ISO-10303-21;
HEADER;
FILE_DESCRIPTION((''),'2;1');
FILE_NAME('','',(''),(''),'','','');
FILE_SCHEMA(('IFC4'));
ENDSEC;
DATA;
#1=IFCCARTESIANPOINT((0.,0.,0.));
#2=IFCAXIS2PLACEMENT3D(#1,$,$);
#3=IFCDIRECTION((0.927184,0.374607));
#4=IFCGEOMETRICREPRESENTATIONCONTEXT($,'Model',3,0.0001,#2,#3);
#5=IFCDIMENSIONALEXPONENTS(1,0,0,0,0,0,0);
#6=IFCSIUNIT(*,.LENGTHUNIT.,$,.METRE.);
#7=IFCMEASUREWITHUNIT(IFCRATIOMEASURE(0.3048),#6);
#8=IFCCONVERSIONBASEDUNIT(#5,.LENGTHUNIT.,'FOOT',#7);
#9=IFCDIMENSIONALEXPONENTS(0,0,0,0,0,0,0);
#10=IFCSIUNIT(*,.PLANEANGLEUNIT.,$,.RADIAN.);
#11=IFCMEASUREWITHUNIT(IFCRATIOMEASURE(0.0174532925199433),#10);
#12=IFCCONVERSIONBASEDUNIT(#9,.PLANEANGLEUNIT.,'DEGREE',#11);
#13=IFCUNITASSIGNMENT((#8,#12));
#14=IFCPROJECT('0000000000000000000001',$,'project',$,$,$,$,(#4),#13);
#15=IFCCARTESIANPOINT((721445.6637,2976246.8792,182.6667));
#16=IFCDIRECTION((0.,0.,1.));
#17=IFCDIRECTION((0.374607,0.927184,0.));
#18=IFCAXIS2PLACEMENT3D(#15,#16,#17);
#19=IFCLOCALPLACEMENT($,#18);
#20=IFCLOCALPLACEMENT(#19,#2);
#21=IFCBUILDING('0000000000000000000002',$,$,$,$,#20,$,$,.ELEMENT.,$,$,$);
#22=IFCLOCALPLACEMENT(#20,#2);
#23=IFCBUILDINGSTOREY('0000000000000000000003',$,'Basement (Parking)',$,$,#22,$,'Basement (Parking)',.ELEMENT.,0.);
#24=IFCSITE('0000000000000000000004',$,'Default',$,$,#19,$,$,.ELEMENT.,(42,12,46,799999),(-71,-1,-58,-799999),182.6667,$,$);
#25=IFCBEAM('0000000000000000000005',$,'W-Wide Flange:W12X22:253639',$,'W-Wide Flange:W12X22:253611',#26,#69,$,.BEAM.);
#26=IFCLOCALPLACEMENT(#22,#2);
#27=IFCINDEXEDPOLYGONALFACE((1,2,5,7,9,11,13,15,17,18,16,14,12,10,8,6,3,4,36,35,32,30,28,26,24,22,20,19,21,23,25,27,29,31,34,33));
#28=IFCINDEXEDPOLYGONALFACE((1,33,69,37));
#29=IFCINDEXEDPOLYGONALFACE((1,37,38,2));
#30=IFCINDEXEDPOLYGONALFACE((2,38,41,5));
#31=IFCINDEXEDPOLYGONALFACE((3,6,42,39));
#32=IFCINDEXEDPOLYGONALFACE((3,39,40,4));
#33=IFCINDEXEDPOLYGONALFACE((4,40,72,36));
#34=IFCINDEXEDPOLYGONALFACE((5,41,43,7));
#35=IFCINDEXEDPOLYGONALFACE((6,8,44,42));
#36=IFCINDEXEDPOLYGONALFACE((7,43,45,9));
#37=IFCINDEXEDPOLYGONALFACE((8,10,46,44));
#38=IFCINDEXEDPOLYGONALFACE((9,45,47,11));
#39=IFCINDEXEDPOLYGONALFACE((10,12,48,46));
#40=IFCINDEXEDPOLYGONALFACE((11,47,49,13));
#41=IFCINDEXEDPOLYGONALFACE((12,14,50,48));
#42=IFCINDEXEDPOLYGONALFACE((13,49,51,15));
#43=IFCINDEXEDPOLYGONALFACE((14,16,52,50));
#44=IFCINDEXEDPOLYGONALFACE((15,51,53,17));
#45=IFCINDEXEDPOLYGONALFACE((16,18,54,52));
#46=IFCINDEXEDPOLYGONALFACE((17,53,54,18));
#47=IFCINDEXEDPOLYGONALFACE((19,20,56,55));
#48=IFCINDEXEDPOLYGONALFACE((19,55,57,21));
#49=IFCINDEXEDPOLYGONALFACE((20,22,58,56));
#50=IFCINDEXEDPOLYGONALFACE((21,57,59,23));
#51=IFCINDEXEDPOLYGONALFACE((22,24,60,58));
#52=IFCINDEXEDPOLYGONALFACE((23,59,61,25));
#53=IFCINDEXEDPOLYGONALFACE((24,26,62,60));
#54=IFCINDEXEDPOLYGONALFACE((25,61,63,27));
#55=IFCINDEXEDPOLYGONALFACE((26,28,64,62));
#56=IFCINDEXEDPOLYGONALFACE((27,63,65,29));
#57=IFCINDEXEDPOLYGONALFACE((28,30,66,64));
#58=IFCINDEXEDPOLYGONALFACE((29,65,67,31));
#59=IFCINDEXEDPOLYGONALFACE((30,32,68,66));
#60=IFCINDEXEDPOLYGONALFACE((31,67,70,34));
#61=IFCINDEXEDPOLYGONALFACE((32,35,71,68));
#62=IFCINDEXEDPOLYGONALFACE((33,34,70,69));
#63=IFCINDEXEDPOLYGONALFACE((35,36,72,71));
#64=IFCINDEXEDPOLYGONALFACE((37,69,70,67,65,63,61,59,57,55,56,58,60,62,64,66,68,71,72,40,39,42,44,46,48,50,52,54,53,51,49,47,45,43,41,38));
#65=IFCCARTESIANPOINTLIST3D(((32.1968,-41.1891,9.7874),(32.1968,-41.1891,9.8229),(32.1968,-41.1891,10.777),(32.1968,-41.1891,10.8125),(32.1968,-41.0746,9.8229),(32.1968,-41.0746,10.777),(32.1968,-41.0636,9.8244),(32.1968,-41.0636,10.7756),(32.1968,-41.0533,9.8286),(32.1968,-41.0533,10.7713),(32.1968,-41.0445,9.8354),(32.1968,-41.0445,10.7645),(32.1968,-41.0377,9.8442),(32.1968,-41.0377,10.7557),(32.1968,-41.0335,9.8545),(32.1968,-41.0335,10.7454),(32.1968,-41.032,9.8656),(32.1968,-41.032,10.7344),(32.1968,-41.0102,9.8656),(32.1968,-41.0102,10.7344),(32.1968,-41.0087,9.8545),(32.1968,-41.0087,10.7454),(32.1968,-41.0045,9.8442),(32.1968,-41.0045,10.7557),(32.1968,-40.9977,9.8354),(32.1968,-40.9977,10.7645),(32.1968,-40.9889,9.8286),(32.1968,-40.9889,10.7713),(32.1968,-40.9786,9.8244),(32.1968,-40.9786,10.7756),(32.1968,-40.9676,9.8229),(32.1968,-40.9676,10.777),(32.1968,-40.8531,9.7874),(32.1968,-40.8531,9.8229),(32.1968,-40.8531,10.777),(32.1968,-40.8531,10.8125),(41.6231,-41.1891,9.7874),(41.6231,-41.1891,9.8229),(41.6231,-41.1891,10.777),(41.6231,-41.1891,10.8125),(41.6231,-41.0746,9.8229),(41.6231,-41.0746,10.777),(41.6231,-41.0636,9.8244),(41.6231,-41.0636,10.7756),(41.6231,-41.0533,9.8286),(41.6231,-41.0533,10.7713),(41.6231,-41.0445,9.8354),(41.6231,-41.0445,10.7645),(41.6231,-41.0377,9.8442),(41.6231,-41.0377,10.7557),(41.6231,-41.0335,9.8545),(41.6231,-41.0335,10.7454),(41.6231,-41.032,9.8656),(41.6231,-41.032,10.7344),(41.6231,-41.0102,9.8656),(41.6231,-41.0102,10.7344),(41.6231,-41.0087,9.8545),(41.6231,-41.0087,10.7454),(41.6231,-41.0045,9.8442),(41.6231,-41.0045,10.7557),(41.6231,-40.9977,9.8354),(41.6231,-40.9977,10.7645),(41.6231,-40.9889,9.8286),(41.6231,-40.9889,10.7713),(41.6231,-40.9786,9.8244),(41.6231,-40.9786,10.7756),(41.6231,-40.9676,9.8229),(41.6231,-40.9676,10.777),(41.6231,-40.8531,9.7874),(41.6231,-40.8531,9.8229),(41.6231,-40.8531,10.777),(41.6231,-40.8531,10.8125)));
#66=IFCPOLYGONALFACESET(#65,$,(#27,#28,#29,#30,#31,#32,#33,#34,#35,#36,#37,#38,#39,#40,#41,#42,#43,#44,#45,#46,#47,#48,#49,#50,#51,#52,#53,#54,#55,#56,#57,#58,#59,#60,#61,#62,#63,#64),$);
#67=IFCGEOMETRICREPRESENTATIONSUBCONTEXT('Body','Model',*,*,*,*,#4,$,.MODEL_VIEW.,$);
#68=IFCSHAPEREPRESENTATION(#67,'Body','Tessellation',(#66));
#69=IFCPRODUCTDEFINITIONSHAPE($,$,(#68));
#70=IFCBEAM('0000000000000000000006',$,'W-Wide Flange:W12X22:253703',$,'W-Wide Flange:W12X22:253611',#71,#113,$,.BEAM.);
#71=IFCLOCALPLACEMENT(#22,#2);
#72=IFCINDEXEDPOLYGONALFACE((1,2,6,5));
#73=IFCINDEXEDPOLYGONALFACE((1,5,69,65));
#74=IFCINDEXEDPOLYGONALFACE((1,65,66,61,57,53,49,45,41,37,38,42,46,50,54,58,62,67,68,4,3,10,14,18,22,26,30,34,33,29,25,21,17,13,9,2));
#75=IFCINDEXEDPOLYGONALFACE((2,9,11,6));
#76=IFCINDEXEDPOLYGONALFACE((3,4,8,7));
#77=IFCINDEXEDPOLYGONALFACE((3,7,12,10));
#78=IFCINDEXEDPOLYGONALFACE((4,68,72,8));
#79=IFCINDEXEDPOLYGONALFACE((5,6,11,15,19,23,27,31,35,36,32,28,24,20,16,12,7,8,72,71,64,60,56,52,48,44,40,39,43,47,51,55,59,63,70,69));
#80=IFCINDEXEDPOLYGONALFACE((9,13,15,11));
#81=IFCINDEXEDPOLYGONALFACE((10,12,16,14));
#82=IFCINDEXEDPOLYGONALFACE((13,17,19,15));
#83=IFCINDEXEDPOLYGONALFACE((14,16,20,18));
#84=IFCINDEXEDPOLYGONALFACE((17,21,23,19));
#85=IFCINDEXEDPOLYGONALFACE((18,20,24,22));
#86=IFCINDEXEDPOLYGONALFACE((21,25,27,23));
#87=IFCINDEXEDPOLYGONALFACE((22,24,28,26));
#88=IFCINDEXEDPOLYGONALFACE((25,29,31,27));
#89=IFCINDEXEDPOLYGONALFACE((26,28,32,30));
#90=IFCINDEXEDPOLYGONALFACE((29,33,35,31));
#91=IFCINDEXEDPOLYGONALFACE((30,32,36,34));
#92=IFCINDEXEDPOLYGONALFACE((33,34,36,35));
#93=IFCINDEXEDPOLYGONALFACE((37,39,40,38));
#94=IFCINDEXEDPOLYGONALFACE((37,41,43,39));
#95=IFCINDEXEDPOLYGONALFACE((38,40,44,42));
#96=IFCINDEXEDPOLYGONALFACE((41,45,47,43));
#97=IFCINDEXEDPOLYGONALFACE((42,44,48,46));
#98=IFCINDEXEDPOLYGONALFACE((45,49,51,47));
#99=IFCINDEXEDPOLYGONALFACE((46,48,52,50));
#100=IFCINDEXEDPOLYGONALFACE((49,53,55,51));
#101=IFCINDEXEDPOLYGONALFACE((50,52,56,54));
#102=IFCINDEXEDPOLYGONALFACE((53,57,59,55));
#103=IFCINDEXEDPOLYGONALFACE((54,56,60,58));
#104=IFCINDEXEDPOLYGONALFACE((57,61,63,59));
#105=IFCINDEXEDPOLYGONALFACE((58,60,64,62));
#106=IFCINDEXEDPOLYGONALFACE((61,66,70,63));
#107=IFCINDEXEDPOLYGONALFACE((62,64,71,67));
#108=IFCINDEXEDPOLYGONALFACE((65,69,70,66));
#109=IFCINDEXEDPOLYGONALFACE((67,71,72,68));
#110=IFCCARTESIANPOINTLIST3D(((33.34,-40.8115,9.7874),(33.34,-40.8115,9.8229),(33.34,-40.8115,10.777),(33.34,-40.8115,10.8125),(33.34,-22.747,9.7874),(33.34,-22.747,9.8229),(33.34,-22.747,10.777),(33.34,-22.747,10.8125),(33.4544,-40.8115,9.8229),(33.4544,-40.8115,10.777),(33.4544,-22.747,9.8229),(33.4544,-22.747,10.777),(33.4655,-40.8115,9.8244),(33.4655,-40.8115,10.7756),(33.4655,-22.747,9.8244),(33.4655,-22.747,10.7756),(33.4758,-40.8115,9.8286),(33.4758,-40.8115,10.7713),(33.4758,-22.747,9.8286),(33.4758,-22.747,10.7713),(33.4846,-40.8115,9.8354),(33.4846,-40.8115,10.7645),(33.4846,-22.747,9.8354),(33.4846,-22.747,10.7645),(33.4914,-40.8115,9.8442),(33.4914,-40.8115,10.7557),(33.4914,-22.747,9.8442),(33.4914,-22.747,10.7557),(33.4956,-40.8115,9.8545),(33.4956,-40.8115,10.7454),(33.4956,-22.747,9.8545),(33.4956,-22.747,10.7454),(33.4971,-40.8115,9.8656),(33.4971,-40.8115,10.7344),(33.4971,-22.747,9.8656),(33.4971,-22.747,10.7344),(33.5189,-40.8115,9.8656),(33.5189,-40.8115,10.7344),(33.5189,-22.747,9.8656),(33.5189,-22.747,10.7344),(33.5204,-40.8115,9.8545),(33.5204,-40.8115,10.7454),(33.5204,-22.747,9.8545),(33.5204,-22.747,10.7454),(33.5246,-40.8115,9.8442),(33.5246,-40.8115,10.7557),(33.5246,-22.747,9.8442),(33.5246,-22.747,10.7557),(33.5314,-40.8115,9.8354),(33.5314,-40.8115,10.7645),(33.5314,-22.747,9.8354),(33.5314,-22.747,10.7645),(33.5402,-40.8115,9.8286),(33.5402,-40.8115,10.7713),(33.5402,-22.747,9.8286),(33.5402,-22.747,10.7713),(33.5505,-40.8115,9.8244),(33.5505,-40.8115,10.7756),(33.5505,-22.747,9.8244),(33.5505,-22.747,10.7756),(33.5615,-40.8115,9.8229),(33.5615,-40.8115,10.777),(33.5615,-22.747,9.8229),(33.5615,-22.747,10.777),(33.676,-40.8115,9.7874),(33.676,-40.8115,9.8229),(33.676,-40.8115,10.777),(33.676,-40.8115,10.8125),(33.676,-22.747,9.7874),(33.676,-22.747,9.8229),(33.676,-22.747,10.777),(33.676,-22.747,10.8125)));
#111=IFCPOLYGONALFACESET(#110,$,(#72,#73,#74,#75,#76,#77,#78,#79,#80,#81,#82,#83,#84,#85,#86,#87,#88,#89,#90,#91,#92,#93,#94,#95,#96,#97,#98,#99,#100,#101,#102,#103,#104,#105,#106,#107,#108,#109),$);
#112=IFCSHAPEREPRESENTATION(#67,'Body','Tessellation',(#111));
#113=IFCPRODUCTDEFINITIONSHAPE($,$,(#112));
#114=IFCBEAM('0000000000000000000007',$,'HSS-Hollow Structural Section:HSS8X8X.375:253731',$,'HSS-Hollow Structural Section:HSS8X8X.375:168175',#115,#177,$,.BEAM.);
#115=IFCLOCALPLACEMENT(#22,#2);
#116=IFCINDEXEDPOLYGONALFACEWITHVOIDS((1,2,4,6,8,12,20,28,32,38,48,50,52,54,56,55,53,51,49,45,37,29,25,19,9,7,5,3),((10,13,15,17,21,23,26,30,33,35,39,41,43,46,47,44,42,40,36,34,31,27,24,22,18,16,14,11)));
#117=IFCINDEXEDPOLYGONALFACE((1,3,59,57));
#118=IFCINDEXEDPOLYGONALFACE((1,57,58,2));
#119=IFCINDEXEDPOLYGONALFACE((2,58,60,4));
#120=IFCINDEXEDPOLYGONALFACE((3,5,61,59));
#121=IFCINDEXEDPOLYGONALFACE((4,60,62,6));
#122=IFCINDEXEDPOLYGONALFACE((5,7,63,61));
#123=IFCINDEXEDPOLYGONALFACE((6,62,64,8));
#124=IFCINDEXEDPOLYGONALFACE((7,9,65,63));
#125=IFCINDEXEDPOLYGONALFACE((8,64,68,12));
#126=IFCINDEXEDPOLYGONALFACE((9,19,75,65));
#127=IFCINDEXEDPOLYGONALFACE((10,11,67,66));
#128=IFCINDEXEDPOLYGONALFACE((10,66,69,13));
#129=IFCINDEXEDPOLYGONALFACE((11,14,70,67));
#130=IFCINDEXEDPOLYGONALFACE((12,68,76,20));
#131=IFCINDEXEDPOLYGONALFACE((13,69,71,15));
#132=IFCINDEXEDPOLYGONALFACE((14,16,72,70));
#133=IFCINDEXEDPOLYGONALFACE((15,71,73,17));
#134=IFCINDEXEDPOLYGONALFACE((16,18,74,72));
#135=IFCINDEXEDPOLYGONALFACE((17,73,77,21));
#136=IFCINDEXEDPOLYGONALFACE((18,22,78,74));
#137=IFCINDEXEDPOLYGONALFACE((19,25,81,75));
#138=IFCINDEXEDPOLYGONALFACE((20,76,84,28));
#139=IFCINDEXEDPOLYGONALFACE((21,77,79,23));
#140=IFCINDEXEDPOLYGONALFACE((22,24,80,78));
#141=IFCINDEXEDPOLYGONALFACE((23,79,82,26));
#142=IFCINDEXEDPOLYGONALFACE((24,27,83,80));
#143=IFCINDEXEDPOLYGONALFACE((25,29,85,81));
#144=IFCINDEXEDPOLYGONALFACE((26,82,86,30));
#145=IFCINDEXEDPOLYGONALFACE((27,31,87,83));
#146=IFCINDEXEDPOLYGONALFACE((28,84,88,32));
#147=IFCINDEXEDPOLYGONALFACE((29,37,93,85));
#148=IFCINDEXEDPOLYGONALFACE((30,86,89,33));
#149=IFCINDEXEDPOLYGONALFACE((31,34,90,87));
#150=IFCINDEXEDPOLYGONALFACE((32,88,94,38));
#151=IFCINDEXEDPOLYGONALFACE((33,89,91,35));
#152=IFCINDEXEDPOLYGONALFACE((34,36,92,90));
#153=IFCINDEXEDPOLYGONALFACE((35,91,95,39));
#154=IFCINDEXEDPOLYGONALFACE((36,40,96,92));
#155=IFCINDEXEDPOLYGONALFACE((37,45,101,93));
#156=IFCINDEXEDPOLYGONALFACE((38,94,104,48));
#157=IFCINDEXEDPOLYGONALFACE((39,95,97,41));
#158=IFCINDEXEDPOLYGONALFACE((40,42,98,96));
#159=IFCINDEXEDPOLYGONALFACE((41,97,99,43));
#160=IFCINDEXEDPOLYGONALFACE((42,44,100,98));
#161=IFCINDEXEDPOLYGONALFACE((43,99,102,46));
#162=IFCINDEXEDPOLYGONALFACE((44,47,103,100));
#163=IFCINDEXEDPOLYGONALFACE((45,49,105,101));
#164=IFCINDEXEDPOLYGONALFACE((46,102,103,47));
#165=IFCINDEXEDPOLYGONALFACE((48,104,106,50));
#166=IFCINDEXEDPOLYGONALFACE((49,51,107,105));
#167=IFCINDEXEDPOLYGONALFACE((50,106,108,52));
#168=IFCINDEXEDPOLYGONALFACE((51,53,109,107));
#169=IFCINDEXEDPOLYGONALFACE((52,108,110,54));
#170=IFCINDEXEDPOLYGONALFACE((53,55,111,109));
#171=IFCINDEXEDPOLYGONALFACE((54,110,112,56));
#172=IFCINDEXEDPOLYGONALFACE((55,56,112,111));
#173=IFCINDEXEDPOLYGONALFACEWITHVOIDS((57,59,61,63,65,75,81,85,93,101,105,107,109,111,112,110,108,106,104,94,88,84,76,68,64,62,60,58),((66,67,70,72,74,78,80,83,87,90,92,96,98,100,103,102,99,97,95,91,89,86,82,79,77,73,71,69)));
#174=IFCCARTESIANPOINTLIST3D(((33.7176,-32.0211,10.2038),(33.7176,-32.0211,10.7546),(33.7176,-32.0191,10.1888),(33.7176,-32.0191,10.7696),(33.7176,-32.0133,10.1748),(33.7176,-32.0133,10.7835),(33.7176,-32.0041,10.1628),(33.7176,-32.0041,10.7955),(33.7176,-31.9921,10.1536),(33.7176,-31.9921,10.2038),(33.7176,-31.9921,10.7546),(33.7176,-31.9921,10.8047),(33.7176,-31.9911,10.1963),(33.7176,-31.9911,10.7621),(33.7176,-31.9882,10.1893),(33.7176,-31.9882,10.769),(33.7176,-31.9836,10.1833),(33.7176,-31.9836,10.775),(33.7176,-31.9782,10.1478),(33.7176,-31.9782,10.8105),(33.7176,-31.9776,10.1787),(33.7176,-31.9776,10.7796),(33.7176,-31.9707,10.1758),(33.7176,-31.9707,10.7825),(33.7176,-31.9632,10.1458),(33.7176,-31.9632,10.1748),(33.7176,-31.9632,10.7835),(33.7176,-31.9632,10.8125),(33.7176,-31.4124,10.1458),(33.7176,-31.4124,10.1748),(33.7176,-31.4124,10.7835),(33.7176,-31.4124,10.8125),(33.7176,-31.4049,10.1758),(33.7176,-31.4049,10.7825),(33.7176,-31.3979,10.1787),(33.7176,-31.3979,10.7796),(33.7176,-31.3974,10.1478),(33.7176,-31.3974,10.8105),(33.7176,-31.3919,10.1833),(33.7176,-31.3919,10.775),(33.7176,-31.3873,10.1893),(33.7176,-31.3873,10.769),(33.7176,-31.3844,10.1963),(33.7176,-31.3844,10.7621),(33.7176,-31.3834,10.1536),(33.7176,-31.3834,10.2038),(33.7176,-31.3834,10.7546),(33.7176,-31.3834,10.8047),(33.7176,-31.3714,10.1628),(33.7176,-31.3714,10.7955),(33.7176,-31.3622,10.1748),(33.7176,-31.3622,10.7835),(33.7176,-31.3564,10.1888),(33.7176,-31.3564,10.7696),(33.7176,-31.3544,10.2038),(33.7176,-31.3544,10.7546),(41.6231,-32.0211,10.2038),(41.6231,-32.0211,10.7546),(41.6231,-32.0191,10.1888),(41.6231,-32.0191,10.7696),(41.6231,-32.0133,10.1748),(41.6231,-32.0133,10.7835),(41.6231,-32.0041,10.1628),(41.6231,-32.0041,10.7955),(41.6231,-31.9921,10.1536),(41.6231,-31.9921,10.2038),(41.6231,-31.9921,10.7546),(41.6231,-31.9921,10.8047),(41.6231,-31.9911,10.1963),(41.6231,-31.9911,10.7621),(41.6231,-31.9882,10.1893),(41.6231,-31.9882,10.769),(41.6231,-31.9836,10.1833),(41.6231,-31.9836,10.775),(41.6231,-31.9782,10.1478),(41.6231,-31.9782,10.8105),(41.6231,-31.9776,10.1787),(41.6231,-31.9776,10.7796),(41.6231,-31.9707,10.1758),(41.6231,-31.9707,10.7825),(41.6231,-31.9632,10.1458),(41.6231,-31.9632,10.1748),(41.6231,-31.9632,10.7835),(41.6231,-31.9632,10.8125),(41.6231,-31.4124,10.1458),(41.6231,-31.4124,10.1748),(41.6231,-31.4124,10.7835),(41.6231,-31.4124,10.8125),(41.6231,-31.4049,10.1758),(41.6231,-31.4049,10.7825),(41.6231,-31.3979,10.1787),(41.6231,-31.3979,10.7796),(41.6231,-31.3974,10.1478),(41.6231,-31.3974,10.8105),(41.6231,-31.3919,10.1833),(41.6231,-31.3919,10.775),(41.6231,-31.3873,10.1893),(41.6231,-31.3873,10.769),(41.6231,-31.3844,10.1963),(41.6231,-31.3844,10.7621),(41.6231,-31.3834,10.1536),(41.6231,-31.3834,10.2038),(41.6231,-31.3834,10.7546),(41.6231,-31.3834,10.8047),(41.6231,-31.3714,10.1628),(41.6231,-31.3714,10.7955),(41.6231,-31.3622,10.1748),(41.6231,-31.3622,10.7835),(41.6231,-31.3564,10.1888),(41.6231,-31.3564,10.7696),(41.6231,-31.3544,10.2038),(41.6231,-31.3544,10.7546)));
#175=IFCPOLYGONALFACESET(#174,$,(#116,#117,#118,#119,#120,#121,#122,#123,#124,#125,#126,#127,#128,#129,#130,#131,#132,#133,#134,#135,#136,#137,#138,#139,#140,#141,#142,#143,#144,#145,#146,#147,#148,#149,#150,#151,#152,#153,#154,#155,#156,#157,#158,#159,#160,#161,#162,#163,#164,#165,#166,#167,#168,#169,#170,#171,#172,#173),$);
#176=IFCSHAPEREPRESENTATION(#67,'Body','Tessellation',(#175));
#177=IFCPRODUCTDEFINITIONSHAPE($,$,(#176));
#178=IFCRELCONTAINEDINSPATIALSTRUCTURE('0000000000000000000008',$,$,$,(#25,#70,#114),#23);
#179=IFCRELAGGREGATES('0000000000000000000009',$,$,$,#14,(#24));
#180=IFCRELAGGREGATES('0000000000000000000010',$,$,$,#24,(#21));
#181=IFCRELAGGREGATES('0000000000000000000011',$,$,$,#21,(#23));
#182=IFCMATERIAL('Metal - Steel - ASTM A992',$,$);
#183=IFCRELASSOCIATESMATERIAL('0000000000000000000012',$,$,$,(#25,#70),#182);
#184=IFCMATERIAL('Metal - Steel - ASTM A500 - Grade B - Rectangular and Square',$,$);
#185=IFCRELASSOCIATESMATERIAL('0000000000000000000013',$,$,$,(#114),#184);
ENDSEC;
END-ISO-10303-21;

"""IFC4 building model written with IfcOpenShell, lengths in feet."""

from ifc_helpers import new_model, entity, si_unit, converted_unit, direction, frame, frame_2d, origin, place, context, subcontext, project, spatial, polyline, circle_curve, parameter, trimmed, segment, composite_curve, i_section, outline, extrude, material, element, save


model = new_model("IFC4")

# Units and contexts
model_context = context("Model", 3, precision=0.0001, world=origin(), true_north=direction((0.927184, 0.374607)))
body_context = subcontext(model_context, "Body", "Model", "MODEL_VIEW")
ifc_project = project(units=[converted_unit("LENGTHUNIT", "FOOT", entity("IfcRatioMeasure", 0.3048), si_unit("LENGTHUNIT", "METRE"), dimensions=[1, 0, 0, 0, 0, 0, 0]), converted_unit("PLANEANGLEUNIT", "DEGREE", entity("IfcRatioMeasure", 0.0174532925199433), si_unit("PLANEANGLEUNIT", "RADIAN"), dimensions=[0, 0, 0, 0, 0, 0, 0])], contexts=[model_context])

# Site, building, storey
site_placement = place(None, frame((721445.6637, 2976246.8792, 182.6667), z_axis=(0.0, 0.0, 1.0), x_axis=(0.374607, 0.927184, 0.0)))
site = spatial("IfcSite", under=ifc_project, at=site_placement, Name="Default", CompositionType="ELEMENT", RefLatitude=(42, 12, 46, 799999), RefLongitude=(-71, -1, -58, -799999), RefElevation=182.6667)
building_placement = place(site_placement, origin())
building = spatial("IfcBuilding", under=site, at=building_placement, CompositionType="ELEMENT")
storey_placement = place(building_placement, origin())
storey = spatial("IfcBuildingStorey", under=building, at=storey_placement, Name="Basement (Parking)", LongName="Basement (Parking)", CompositionType="ELEMENT", Elevation=0.0)

# Shared definitions
ifc_material_1 = material(Name="Metal - Steel - ASTM A992")

# Shared definitions
ifc_material_2 = material(Name="Metal - Steel - ASTM A500 - Grade B - Rectangular and Square")

# Beams
beam_1_placement = place(storey_placement, frame((31.9247, -41.0211, 10.8125)))
element("IfcBeam", 1, at=beam_1_placement, inside=storey, material=ifc_material_1, Name="W-Wide Flange:W12X22:253639", ObjectType="W-Wide Flange:W12X22:253611", PredefinedType="BEAM", context=body_context, shape_type="SweptSolid", body=[
    extrude(i_section(OverallWidth=0.3359, OverallDepth=1.0251, WebThickness=0.0218, FlangeThickness=0.0355, FilletRadius=0.0426, at=frame_2d((0.0, 0.0), x_axis=(0.0, 1.0))), frame((0.2721, 0.0, -0.5125), z_axis=(1.0, 0.0, 0.0), x_axis=(0.0, 0.0, -1.0)), (0.0, 0.0, 1.0), 9.4263),
])
beam_2_placement = place(storey_placement, frame((33.508, -41.0211, 10.8125), z_axis=(0.0, 0.0, 1.0), x_axis=(0.0, 1.0, 0.0)))
element("IfcBeam", 2, at=beam_2_placement, inside=storey, material=ifc_material_1, Name="W-Wide Flange:W12X22:253703", ObjectType="W-Wide Flange:W12X22:253611", PredefinedType="BEAM", context=body_context, shape_type="SweptSolid", body=[
    extrude(i_section(OverallWidth=0.3359, OverallDepth=1.0251, WebThickness=0.0218, FlangeThickness=0.0355, FilletRadius=0.0426, at=frame_2d((0.0, 0.0), x_axis=(0.0, 1.0))), frame((0.2096, 0.0, -0.5125), z_axis=(1.0, 0.0, 0.0), x_axis=(0.0, 0.0, -1.0)), (0.0, 0.0, 1.0), 18.0645),
])
beam_3_placement = place(storey_placement, frame((33.7176, -32.0263, 10.1406)))
element("IfcBeam", 3, at=beam_3_placement, inside=storey, material=ifc_material_2, Name="HSS-Hollow Structural Section:HSS8X8X.375:253731", ObjectType="HSS-Hollow Structural Section:HSS8X8X.375:168175", PredefinedType="BEAM", context=body_context, shape_type="SweptSolid", body=[
    extrude(outline(composite_curve([segment(trimmed(circle_curve(frame_2d((-0.2754, -0.2754), x_axis=(1.0, 0.0)), 0.0579), [parameter(180.0)], [parameter(270.0)], True, "PARAMETER"), True, "CONTINUOUS"), segment(polyline([(-0.2754, -0.3333), (0.2754, -0.3333)]), True, "CONTINUOUS"), segment(trimmed(circle_curve(frame_2d((0.2754, -0.2754), x_axis=(1.0, 0.0)), 0.0579), [parameter(270.0)], [parameter(0.0)], True, "PARAMETER"), True, "CONTINUOUS"), segment(polyline([(0.3333, -0.2754), (0.3333, 0.2754)]), True, "CONTINUOUS"), segment(trimmed(circle_curve(frame_2d((0.2754, 0.2754), x_axis=(1.0, 0.0)), 0.0579), [parameter(360.0)], [parameter(90.0)], True, "PARAMETER"), True, "CONTINUOUS"), segment(polyline([(0.2754, 0.3333), (-0.2754, 0.3333)]), True, "CONTINUOUS"), segment(trimmed(circle_curve(frame_2d((-0.2754, 0.2754), x_axis=(1.0, 0.0)), 0.0579), [parameter(90.0)], [parameter(180.0)], True, "PARAMETER"), True, "CONTINUOUS"), segment(polyline([(-0.3333, 0.2754), (-0.3333, -0.2754)]), True, "CONTINUOUS")], self_intersect=False), holes=[composite_curve([segment(polyline([(0.2754, -0.3044), (-0.2754, -0.3044)]), True, "CONTINUOUS"), segment(trimmed(circle_curve(frame_2d((-0.2754, -0.2754), x_axis=(1.0, 0.0)), 0.029), [parameter(180.0)], [parameter(270.0)], True, "PARAMETER"), False, "CONTINUOUS"), segment(polyline([(-0.3044, -0.2754), (-0.3044, 0.2754)]), True, "CONTINUOUS"), segment(trimmed(circle_curve(frame_2d((-0.2754, 0.2754), x_axis=(1.0, 0.0)), 0.029), [parameter(90.0)], [parameter(180.0)], True, "PARAMETER"), False, "CONTINUOUS"), segment(polyline([(-0.2754, 0.3044), (0.2754, 0.3044)]), True, "CONTINUOUS"), segment(trimmed(circle_curve(frame_2d((0.2754, 0.2754), x_axis=(1.0, 0.0)), 0.029), [parameter(0.0)], [parameter(90.0)], True, "PARAMETER"), False, "CONTINUOUS"), segment(polyline([(0.3044, 0.2754), (0.3044, -0.2754)]), True, "CONTINUOUS"), segment(trimmed(circle_curve(frame_2d((0.2754, -0.2754), x_axis=(1.0, 0.0)), 0.029), [parameter(270.0)], [parameter(0.0)], True, "PARAMETER"), False, "CONTINUOUS")], self_intersect=False)]), frame((0.0, 0.3386, 0.3386), z_axis=(1.0, 0.0, 0.0), x_axis=(0.0, -1.0, 0.0)), (0.0, 0.0, 1.0), 7.9054),
])

save(model, "model.ifc")
